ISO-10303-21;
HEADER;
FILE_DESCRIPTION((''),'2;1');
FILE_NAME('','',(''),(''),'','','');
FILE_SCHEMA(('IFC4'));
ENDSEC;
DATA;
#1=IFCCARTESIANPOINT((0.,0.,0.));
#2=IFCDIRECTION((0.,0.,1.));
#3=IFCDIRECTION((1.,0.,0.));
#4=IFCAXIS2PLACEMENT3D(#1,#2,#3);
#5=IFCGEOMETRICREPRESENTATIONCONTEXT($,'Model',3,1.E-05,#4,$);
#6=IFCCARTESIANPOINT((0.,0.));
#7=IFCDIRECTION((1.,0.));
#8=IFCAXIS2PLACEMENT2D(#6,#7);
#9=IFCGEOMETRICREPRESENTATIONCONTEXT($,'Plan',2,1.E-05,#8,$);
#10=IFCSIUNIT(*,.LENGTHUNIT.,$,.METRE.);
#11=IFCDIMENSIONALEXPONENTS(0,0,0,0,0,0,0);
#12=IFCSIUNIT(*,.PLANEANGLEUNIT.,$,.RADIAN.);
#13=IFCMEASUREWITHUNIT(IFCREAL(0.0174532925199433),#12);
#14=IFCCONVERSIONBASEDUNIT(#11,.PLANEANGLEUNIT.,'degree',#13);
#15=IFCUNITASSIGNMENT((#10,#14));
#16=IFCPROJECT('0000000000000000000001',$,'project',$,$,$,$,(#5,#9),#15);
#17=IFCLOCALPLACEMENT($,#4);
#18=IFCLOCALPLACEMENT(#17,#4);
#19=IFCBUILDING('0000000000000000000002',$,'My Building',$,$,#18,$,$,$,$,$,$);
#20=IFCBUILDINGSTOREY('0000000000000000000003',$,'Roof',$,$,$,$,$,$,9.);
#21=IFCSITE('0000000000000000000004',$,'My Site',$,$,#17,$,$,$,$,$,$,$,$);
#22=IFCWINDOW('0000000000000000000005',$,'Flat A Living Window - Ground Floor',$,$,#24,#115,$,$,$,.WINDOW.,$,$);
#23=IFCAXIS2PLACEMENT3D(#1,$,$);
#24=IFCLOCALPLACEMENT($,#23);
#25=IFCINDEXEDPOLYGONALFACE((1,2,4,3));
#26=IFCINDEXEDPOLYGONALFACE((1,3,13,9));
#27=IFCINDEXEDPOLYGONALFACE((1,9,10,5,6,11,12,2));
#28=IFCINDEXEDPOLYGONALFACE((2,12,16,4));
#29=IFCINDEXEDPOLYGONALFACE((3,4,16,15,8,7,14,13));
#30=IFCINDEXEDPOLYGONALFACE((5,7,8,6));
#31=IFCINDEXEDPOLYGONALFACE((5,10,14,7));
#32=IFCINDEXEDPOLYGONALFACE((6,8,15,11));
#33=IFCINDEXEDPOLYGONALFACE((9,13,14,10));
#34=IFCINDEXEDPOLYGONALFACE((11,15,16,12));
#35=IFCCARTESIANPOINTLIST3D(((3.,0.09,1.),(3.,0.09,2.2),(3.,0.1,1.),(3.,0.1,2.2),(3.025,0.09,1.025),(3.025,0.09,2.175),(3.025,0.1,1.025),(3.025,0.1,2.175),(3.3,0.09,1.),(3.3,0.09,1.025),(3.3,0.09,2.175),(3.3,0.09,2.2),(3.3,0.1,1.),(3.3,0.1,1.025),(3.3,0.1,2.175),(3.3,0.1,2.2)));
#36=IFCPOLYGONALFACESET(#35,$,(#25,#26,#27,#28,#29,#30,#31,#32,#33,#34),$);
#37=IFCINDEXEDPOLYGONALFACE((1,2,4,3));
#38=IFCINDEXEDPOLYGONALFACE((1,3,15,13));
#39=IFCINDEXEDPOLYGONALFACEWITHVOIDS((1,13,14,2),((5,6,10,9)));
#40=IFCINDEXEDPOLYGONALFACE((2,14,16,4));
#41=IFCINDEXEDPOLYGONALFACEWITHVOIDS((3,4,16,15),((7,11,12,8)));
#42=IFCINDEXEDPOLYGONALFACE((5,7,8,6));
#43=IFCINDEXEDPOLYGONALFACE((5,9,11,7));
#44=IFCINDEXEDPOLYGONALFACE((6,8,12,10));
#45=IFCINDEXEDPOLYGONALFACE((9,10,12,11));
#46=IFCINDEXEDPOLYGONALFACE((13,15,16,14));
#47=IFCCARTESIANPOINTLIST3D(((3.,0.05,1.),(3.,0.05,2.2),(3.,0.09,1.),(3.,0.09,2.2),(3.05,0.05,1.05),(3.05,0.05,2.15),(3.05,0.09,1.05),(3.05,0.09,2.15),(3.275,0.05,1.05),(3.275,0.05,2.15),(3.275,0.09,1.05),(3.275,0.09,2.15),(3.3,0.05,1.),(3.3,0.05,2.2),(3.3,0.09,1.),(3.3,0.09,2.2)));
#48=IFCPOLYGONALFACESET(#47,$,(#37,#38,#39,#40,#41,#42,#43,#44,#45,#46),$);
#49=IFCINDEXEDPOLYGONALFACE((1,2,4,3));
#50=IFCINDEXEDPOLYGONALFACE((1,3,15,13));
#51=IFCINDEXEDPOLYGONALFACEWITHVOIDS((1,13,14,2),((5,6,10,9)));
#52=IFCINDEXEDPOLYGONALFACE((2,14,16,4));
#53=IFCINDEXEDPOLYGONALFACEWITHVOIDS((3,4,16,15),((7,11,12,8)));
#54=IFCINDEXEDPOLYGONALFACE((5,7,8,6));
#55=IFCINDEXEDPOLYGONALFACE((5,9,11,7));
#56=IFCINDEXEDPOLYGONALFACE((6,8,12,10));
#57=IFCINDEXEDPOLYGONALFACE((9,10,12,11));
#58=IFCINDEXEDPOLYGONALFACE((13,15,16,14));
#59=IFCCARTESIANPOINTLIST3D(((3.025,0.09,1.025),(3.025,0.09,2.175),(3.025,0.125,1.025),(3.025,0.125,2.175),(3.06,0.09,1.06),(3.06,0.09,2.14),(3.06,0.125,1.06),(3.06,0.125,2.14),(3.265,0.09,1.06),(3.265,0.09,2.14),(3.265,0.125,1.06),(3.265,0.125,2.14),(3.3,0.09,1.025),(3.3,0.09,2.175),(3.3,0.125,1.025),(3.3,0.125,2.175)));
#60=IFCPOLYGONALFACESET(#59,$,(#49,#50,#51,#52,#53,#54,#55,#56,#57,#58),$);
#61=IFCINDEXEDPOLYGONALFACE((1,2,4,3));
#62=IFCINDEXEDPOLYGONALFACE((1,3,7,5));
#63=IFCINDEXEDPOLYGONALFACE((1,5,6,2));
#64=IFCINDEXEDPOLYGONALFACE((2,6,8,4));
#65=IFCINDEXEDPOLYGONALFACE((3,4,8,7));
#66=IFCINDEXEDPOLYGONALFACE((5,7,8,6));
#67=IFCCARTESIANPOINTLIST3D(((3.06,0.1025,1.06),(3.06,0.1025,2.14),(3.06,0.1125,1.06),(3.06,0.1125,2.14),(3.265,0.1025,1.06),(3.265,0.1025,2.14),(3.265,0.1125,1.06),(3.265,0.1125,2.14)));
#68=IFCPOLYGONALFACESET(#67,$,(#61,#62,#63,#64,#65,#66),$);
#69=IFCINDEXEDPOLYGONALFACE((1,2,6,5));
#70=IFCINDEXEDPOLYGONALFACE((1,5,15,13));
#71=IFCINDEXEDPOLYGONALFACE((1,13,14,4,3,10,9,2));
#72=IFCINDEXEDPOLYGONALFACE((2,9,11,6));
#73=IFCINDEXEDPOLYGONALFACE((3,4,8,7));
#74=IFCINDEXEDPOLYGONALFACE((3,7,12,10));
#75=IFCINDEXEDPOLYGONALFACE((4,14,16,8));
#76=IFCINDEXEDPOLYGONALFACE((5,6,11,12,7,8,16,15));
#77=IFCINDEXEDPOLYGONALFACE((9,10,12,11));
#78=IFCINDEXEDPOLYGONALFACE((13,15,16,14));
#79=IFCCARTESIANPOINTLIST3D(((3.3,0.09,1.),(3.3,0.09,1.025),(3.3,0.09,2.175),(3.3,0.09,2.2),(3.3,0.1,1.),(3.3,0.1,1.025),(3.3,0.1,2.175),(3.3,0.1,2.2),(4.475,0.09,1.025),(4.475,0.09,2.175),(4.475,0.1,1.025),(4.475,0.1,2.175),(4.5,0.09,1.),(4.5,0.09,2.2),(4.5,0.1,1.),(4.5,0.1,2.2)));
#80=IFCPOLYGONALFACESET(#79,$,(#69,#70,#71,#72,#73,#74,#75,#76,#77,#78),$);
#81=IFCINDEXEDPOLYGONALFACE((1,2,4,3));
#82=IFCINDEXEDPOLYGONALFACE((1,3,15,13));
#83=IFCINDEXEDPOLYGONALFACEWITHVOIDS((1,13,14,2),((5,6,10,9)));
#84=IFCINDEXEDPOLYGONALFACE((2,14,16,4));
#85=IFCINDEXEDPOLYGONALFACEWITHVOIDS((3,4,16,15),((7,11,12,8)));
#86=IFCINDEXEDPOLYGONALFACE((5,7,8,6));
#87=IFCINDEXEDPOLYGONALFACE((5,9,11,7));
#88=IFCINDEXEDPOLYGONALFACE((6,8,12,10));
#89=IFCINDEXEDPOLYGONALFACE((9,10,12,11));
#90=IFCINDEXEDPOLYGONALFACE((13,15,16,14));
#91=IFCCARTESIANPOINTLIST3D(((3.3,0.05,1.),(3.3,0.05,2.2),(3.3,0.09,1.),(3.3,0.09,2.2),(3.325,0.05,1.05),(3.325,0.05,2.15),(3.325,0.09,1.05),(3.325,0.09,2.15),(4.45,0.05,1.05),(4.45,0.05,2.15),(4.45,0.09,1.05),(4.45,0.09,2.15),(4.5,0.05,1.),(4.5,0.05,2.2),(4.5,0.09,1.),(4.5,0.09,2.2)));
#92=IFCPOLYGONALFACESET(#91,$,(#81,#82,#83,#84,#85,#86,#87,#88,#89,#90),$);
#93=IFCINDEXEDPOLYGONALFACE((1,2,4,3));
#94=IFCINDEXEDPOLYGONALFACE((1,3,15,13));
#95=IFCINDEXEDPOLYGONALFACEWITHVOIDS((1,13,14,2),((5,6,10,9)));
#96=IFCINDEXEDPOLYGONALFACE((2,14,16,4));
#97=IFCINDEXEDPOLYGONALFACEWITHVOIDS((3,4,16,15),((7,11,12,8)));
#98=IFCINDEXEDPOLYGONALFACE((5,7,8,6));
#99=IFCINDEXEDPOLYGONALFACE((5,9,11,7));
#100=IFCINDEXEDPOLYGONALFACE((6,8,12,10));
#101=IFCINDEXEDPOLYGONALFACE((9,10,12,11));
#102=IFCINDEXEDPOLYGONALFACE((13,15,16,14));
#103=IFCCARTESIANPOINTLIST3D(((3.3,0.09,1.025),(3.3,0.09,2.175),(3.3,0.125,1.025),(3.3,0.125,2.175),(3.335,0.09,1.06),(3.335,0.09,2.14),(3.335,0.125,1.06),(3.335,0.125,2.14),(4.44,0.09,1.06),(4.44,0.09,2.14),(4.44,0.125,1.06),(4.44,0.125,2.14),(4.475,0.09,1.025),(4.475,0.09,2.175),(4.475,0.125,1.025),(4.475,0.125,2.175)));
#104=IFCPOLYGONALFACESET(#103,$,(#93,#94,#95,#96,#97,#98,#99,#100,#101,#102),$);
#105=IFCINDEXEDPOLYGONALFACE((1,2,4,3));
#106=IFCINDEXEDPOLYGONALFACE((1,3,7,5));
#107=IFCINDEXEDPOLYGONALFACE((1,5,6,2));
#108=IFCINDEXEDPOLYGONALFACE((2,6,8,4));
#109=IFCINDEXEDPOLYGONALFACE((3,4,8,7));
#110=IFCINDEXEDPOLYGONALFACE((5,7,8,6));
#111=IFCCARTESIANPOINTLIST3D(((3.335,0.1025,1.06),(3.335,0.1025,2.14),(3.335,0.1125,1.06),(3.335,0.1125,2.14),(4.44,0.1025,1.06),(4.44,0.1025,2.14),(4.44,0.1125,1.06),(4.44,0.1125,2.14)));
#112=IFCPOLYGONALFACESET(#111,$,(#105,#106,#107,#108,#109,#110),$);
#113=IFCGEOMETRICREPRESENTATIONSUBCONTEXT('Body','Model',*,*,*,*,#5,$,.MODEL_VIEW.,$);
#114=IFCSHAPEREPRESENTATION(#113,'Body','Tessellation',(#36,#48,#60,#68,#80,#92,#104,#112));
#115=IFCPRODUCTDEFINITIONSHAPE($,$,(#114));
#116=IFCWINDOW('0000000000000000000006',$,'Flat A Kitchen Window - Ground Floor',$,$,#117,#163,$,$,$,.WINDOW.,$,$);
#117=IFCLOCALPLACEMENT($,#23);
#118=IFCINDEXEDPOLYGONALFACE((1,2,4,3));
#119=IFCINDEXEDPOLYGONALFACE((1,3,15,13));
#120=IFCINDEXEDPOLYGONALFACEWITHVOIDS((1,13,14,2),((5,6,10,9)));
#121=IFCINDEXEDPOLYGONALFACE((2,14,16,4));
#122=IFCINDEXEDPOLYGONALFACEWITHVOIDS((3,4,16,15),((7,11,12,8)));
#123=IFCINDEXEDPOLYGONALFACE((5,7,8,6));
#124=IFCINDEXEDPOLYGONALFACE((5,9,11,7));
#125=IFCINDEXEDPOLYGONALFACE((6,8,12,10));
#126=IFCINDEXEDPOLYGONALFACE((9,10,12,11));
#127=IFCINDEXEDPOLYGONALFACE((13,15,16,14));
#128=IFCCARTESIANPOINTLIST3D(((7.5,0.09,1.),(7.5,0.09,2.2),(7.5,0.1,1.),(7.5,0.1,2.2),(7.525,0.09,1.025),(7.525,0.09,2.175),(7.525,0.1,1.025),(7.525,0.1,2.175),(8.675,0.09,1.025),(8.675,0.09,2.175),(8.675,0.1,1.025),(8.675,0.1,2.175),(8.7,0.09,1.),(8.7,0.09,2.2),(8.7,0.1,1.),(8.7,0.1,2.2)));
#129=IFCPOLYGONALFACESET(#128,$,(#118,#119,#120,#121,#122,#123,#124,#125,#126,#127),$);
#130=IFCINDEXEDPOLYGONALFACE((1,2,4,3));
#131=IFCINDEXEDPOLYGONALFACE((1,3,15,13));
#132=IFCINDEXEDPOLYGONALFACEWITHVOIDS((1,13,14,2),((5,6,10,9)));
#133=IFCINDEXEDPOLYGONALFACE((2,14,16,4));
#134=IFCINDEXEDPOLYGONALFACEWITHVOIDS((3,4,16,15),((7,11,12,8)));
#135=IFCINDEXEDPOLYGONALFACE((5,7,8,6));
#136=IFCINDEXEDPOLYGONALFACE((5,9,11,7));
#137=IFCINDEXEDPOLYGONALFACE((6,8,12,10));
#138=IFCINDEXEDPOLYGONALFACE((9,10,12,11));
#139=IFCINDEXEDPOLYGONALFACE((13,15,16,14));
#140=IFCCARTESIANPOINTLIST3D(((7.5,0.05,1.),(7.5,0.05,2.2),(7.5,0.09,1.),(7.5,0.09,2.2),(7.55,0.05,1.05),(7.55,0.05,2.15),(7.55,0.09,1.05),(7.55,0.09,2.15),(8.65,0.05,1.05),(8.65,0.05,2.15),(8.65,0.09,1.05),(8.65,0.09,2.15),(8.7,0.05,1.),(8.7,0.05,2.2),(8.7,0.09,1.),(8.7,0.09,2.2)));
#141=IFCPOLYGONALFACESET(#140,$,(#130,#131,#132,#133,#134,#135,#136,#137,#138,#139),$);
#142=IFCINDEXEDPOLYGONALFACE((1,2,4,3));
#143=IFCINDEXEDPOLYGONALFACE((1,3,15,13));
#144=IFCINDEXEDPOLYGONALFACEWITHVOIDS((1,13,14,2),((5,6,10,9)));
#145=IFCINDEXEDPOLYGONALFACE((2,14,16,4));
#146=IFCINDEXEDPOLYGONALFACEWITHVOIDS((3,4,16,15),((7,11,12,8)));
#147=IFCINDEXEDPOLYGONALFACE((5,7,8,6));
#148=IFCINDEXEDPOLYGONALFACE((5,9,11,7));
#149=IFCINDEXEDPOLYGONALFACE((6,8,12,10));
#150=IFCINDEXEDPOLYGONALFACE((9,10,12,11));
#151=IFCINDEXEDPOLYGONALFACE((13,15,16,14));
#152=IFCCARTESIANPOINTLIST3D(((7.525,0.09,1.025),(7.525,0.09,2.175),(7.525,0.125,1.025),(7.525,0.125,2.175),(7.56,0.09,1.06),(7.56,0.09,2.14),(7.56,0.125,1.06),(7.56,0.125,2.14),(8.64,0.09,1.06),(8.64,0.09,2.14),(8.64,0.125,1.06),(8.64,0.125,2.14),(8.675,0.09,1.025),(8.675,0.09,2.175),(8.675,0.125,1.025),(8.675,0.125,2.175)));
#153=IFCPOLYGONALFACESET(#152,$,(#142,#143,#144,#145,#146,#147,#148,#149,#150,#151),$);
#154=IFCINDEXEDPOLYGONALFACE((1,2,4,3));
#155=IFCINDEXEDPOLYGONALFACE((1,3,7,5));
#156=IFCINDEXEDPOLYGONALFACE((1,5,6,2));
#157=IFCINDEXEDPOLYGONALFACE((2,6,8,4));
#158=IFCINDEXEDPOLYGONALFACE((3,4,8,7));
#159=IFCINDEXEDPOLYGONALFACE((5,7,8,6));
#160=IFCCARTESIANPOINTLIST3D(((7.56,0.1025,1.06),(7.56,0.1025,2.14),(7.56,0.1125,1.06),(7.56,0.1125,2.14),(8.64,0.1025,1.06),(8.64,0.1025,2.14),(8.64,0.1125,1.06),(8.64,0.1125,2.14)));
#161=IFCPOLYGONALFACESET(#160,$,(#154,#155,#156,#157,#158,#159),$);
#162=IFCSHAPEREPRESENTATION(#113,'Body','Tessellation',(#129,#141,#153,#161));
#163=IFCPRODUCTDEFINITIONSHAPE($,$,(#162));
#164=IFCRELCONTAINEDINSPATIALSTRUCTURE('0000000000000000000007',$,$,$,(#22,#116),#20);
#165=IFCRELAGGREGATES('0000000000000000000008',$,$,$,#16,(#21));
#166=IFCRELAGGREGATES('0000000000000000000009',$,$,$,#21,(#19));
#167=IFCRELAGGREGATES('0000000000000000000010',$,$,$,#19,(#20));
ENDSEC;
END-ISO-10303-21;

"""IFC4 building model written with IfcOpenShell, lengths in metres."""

from ifc_helpers import new_model, entity, si_unit, converted_unit, frame, origin_with_axes, origin_2d_with_axis, place, context, subcontext, project, spatial, line, indexed_curve, outline, extrude, element, save


model = new_model("IFC4")

# Units and contexts
model_context = context("Model", 3, precision=1e-05, world=origin_with_axes())
plan_context = context("Plan", 2, precision=1e-05, world=origin_2d_with_axis())
body_context = subcontext(model_context, "Body", "Model", "MODEL_VIEW")
ifc_project = project(units=[si_unit("LENGTHUNIT", "METRE"), converted_unit("PLANEANGLEUNIT", "degree", entity("IfcReal", 0.0174532925199433), si_unit("PLANEANGLEUNIT", "RADIAN"), dimensions=[0, 0, 0, 0, 0, 0, 0])], contexts=[model_context, plan_context])

# Site, building, storey
site_placement = place(None, origin_with_axes())
site = spatial("IfcSite", under=ifc_project, at=site_placement, Name="My Site")
building_placement = place(site_placement, origin_with_axes())
building = spatial("IfcBuilding", under=site, at=building_placement, Name="My Building")
storey = spatial("IfcBuildingStorey", under=building, Name="Roof", Elevation=9.0)

# Windows
window_1_placement = place(None, frame((3.0, 0.0, 1.0), z_axis=(0.0, 0.0, 1.0), x_axis=(1.0, 0.0, 0.0)))
element("IfcWindow", 1, at=window_1_placement, inside=storey, Name="Flat A Living Window - Ground Floor", PredefinedType="WINDOW", context=body_context, shape_type="SweptSolid", body=[
    extrude(outline(indexed_curve([(0.3, 0.0), (0.0, 0.0), (0.0, 1.2), (0.3, 1.2), (0.3, 1.175), (0.025, 1.175), (0.025, 0.025), (0.3, 0.025)], segments=[line(1, 2, 3, 4, 5, 6, 7, 8, 1)])), frame((0.0, 0.09, 0.0), z_axis=(0.0, -1.0, 0.0), x_axis=(1.0, 0.0, 0.0)), (0.0, 0.0, -1.0), 0.01),
    extrude(outline(indexed_curve([(0.0, 0.0), (0.3, 0.0), (0.3, 1.2), (0.0, 1.2)], segments=[line(1, 2, 3, 4, 1)]), holes=[indexed_curve([(0.05, 0.05), (0.275, 0.05), (0.275, 1.15), (0.05, 1.15)], segments=[line(1, 2, 3, 4, 1)])]), frame((0.0, 0.05, 0.0), z_axis=(0.0, -1.0, 0.0), x_axis=(1.0, 0.0, 0.0)), (0.0, 0.0, -1.0), 0.04),
    extrude(outline(indexed_curve([(0.0, 0.0), (0.275, 0.0), (0.275, 1.15), (0.0, 1.15)], segments=[line(1, 2, 3, 4, 1)]), holes=[indexed_curve([(0.035, 0.035), (0.24, 0.035), (0.24, 1.115), (0.035, 1.115)], segments=[line(1, 2, 3, 4, 1)])]), frame((0.025, 0.09, 0.025), z_axis=(0.0, -1.0, 0.0), x_axis=(1.0, 0.0, 0.0)), (0.0, 0.0, -1.0), 0.035),
    extrude(outline(indexed_curve([(0.035, 0.035), (0.24, 0.035), (0.24, 1.115), (0.035, 1.115)], segments=[line(1, 2, 3, 4, 1)])), frame((0.025, 0.1025, 0.025), z_axis=(0.0, -1.0, 0.0), x_axis=(1.0, 0.0, 0.0)), (0.0, 0.0, -1.0), 0.01),
    extrude(outline(indexed_curve([(0.0, 1.2), (1.2, 1.2), (1.2, 0.0), (0.0, 0.0), (0.0, 0.025), (1.175, 0.025), (1.175, 1.175), (0.0, 1.175)], segments=[line(1, 2, 3, 4, 5, 6, 7, 8, 1)])), frame((0.3, 0.09, 0.0), z_axis=(0.0, -1.0, 0.0), x_axis=(1.0, 0.0, 0.0)), (0.0, 0.0, -1.0), 0.01),
    extrude(outline(indexed_curve([(0.0, 0.0), (1.2, 0.0), (1.2, 1.2), (0.0, 1.2)], segments=[line(1, 2, 3, 4, 1)]), holes=[indexed_curve([(0.025, 0.05), (1.15, 0.05), (1.15, 1.15), (0.025, 1.15)], segments=[line(1, 2, 3, 4, 1)])]), frame((0.3, 0.05, 0.0), z_axis=(0.0, -1.0, 0.0), x_axis=(1.0, 0.0, 0.0)), (0.0, 0.0, -1.0), 0.04),
    extrude(outline(indexed_curve([(0.0, 0.0), (1.175, 0.0), (1.175, 1.15), (0.0, 1.15)], segments=[line(1, 2, 3, 4, 1)]), holes=[indexed_curve([(0.035, 0.035), (1.14, 0.035), (1.14, 1.115), (0.035, 1.115)], segments=[line(1, 2, 3, 4, 1)])]), frame((0.3, 0.09, 0.025), z_axis=(0.0, -1.0, 0.0), x_axis=(1.0, 0.0, 0.0)), (0.0, 0.0, -1.0), 0.035),
    extrude(outline(indexed_curve([(0.035, 0.035), (1.14, 0.035), (1.14, 1.115), (0.035, 1.115)], segments=[line(1, 2, 3, 4, 1)])), frame((0.3, 0.1025, 0.025), z_axis=(0.0, -1.0, 0.0), x_axis=(1.0, 0.0, 0.0)), (0.0, 0.0, -1.0), 0.01),
])
window_2_placement = place(None, frame((7.5, 0.0, 1.0), z_axis=(0.0, 0.0, 1.0), x_axis=(1.0, 0.0, 0.0)))
element("IfcWindow", 2, at=window_2_placement, inside=storey, Name="Flat A Kitchen Window - Ground Floor", PredefinedType="WINDOW", context=body_context, shape_type="SweptSolid", body=[
    extrude(outline(indexed_curve([(0.0, 0.0), (1.2, 0.0), (1.2, 1.2), (0.0, 1.2)], segments=[line(1, 2, 3, 4, 1)]), holes=[indexed_curve([(0.025, 0.025), (1.175, 0.025), (1.175, 1.175), (0.025, 1.175)], segments=[line(1, 2, 3, 4, 1)])]), frame((0.0, 0.09, 0.0), z_axis=(0.0, -1.0, 0.0), x_axis=(1.0, 0.0, 0.0)), (0.0, 0.0, -1.0), 0.01),
    extrude(outline(indexed_curve([(0.0, 0.0), (1.2, 0.0), (1.2, 1.2), (0.0, 1.2)], segments=[line(1, 2, 3, 4, 1)]), holes=[indexed_curve([(0.05, 0.05), (1.15, 0.05), (1.15, 1.15), (0.05, 1.15)], segments=[line(1, 2, 3, 4, 1)])]), frame((0.0, 0.05, 0.0), z_axis=(0.0, -1.0, 0.0), x_axis=(1.0, 0.0, 0.0)), (0.0, 0.0, -1.0), 0.04),
    extrude(outline(indexed_curve([(0.0, 0.0), (1.15, 0.0), (1.15, 1.15), (0.0, 1.15)], segments=[line(1, 2, 3, 4, 1)]), holes=[indexed_curve([(0.035, 0.035), (1.115, 0.035), (1.115, 1.115), (0.035, 1.115)], segments=[line(1, 2, 3, 4, 1)])]), frame((0.025, 0.09, 0.025), z_axis=(0.0, -1.0, 0.0), x_axis=(1.0, 0.0, 0.0)), (0.0, 0.0, -1.0), 0.035),
    extrude(outline(indexed_curve([(0.035, 0.035), (1.115, 0.035), (1.115, 1.115), (0.035, 1.115)], segments=[line(1, 2, 3, 4, 1)])), frame((0.025, 0.1025, 0.025), z_axis=(0.0, -1.0, 0.0), x_axis=(1.0, 0.0, 0.0)), (0.0, 0.0, -1.0), 0.01),
])

save(model, "model.ifc")
